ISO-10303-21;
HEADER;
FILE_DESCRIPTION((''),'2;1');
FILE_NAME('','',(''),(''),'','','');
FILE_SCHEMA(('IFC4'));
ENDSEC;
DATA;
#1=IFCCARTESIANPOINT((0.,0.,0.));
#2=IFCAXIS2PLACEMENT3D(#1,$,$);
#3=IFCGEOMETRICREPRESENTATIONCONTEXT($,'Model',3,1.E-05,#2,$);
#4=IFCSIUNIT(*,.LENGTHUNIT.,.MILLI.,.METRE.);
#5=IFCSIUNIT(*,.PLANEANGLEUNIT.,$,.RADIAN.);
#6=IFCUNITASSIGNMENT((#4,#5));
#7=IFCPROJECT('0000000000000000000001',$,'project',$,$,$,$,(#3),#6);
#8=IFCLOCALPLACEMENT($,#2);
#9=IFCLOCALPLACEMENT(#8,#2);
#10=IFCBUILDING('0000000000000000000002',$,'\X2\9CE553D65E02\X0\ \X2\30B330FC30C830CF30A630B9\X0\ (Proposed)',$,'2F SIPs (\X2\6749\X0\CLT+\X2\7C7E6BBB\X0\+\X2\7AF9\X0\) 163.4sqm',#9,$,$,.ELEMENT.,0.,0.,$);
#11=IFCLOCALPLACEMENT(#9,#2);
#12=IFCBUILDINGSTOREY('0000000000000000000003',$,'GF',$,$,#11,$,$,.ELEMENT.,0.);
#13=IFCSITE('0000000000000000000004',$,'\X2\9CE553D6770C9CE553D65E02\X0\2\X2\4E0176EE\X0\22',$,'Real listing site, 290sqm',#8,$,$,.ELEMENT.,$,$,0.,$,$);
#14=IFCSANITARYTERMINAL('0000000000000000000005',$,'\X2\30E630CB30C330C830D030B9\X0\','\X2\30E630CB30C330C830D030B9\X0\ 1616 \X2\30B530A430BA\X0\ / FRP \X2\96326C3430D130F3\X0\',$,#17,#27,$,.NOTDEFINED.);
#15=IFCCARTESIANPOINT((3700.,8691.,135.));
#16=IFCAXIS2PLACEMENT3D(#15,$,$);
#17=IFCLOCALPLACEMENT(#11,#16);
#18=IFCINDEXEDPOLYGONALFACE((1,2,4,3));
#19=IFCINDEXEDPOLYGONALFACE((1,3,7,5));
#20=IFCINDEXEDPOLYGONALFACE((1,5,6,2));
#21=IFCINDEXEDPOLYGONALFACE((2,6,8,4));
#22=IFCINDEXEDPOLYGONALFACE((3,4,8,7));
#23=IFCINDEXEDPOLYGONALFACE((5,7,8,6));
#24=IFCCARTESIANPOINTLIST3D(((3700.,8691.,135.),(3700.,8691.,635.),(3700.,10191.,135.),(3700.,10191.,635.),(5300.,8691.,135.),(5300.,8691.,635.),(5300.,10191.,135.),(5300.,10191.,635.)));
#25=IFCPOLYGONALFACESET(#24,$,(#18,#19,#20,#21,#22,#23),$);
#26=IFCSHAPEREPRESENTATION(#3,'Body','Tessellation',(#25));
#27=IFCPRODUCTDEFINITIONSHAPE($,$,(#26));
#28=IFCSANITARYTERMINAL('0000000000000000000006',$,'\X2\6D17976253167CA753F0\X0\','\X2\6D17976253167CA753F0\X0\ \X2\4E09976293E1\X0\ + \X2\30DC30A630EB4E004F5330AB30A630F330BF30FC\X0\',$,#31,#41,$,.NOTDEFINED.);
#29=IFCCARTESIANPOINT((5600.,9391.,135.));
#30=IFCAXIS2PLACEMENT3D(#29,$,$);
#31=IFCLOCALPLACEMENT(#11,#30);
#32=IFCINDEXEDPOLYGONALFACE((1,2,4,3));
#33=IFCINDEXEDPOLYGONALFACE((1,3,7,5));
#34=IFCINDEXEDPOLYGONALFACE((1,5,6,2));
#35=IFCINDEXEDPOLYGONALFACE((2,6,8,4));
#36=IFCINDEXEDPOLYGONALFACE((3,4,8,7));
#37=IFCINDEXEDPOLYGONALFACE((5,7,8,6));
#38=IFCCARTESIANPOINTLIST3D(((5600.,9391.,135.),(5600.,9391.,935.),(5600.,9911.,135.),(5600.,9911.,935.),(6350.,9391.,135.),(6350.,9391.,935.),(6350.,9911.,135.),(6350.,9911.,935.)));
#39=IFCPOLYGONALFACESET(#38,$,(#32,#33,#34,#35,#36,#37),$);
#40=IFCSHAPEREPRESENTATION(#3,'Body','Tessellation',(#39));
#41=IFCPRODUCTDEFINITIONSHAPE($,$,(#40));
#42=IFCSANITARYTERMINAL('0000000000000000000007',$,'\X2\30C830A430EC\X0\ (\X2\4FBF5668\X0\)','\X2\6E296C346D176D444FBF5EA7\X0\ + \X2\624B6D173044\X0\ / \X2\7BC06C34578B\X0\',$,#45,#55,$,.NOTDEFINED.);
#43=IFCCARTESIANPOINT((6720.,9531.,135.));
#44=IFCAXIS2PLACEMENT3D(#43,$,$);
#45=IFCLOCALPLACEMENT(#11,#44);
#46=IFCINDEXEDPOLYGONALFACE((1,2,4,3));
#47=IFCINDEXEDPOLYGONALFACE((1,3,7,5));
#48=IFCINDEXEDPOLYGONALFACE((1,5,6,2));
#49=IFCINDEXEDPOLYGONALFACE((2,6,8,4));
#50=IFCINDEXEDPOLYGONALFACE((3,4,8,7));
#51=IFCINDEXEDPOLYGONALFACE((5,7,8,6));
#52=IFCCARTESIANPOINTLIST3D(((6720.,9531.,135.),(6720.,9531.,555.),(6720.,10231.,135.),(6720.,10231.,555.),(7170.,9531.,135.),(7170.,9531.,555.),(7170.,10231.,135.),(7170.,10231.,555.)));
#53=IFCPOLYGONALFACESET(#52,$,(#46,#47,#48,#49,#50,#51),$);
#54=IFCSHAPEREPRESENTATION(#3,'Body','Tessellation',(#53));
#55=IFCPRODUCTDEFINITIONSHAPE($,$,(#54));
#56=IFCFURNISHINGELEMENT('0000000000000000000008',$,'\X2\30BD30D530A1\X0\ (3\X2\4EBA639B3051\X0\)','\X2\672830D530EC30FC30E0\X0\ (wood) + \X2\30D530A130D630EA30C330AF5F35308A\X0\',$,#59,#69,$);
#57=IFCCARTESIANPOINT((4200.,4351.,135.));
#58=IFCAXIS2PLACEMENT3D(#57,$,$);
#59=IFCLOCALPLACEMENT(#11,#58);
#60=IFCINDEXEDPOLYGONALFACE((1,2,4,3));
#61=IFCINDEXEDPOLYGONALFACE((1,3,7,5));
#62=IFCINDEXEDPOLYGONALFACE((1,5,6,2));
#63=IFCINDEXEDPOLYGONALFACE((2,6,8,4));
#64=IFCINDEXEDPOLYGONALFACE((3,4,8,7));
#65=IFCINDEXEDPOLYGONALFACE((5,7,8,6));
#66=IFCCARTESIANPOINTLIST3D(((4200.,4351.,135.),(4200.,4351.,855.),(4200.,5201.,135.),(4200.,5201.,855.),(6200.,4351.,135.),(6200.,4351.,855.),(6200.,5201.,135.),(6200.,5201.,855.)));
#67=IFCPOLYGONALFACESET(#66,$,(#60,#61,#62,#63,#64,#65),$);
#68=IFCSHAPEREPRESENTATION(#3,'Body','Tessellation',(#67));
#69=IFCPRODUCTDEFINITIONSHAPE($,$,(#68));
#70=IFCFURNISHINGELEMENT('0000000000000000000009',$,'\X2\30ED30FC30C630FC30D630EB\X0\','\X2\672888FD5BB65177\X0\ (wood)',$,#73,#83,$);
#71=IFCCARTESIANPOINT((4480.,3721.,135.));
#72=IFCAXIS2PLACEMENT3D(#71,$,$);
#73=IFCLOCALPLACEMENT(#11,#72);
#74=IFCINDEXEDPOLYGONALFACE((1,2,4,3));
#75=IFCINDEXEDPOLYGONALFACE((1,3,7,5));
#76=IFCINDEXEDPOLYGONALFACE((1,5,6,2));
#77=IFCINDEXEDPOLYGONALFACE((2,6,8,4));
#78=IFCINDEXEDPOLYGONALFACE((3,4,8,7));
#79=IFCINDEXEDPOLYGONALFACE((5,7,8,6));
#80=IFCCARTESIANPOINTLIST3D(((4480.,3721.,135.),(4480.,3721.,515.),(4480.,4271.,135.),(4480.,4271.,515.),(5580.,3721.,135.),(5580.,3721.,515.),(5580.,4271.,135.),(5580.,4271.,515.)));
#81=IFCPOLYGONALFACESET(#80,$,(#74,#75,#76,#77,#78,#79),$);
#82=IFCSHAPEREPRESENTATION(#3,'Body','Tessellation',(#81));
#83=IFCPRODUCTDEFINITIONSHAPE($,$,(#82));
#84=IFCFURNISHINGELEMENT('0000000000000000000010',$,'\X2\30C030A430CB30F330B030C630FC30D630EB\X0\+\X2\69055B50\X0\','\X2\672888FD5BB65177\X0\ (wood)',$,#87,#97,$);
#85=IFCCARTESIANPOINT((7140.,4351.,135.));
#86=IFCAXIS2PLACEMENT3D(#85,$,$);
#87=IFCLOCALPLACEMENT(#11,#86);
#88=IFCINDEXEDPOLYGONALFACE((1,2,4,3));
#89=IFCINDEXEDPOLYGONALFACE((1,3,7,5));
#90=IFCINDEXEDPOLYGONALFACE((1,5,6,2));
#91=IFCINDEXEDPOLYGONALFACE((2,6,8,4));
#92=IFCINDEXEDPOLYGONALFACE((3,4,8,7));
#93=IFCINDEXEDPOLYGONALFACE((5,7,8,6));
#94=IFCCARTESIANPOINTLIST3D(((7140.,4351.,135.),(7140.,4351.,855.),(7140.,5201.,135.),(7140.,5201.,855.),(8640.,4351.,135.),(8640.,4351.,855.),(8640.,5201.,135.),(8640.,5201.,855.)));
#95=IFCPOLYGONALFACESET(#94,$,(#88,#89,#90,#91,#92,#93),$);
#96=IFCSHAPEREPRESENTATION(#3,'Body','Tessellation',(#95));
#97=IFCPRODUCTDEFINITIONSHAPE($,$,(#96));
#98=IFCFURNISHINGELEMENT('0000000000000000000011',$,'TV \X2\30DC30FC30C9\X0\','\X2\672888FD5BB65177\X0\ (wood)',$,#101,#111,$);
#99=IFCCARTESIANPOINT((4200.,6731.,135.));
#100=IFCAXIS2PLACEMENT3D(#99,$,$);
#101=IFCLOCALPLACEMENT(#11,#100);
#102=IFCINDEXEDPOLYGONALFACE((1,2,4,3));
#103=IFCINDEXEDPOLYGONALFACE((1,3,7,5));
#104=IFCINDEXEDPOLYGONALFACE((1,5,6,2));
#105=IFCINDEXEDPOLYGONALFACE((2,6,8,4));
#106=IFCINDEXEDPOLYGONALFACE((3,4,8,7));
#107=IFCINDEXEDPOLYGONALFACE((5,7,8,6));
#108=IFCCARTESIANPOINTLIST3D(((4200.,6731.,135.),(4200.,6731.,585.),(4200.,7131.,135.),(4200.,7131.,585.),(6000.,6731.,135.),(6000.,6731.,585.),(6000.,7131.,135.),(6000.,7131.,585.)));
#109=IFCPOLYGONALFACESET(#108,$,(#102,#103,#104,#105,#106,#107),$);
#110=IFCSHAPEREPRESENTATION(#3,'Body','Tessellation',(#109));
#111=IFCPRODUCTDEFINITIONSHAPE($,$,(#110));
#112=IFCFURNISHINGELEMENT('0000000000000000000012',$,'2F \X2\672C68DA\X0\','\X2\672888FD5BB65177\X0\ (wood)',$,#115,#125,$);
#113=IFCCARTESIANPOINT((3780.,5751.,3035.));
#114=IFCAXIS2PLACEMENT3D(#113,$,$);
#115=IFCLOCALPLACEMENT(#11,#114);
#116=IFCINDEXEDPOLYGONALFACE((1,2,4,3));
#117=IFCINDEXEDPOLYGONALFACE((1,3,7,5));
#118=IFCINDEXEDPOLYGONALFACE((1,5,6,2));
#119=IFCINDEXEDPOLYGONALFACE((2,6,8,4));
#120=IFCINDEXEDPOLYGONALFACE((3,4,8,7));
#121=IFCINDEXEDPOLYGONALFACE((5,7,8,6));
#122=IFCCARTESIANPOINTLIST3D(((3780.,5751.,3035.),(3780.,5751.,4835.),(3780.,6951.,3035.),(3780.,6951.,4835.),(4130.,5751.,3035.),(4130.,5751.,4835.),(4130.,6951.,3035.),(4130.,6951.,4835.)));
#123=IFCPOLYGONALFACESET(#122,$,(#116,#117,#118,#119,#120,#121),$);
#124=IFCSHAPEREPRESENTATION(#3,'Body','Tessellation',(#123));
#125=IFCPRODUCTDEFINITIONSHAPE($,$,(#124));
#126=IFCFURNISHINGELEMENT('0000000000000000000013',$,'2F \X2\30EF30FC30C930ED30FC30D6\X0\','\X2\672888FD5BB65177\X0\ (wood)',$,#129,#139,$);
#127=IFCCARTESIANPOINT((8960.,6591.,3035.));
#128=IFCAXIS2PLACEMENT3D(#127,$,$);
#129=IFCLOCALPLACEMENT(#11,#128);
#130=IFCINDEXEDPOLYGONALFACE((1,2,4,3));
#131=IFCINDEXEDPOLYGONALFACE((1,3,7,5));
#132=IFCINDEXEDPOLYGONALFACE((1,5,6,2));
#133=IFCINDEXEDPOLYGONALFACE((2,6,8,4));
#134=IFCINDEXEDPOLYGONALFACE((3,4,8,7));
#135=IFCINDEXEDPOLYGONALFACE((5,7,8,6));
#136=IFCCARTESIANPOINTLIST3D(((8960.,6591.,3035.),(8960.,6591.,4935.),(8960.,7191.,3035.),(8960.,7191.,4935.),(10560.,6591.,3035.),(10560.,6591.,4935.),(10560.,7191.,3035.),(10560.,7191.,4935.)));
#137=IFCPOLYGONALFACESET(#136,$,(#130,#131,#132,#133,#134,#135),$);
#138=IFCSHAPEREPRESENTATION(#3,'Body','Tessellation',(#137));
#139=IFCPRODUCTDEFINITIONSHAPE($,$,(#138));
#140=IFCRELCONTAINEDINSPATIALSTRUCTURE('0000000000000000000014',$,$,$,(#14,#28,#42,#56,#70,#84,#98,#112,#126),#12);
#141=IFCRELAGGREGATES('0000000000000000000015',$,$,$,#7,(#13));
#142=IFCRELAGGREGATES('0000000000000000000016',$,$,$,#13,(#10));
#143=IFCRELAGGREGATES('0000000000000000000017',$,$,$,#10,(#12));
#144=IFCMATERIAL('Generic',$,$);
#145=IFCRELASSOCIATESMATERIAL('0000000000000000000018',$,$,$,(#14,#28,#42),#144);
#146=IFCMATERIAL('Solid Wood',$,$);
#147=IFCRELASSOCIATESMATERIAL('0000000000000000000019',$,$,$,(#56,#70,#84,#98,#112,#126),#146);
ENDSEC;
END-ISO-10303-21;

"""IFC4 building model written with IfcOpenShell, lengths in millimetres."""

from ifc_helpers import new_model, si_unit, frame, frame_2d, origin, place, context, project, spatial, rectangle, extrude, material, element, save


model = new_model("IFC4")

# Units and contexts
model_context = context("Model", 3, precision=1e-05, world=origin())
ifc_project = project(units=[si_unit("LENGTHUNIT", "METRE", prefix="MILLI"), si_unit("PLANEANGLEUNIT", "RADIAN")], contexts=[model_context])

# Site, building, storey
site_placement = place(None, origin())
site = spatial("IfcSite", under=ifc_project, at=site_placement, Name="鳥取県鳥取市2丁目22", ObjectType="Real listing site, 290sqm", CompositionType="ELEMENT", RefElevation=0.0)
building_placement = place(site_placement, origin())
building = spatial("IfcBuilding", under=site, at=building_placement, Name="鳥取市 コートハウス (Proposed)", ObjectType="2F SIPs (杉CLT+籾殻+竹) 163.4sqm", CompositionType="ELEMENT", ElevationOfRefHeight=0.0, ElevationOfTerrain=0.0)
storey_placement = place(building_placement, origin())
storey = spatial("IfcBuildingStorey", under=building, at=storey_placement, Name="GF", CompositionType="ELEMENT", Elevation=0.0)

# Shared definitions
ifc_material_1 = material(Name="Generic")

# Shared definitions
ifc_material_2 = material(Name="Solid Wood")

# Sanitary terminals
sanitary_terminal_1_placement = place(storey_placement, frame((3700.0, 8691.0, 135.0)))
element("IfcSanitaryTerminal", 1, at=sanitary_terminal_1_placement, inside=storey, material=ifc_material_1, Name="ユニットバス", Description="ユニットバス 1616 サイズ / FRP 防水パン", PredefinedType="NOTDEFINED", context=model_context, shape_type="SweptSolid", body=[
    extrude(rectangle(XDim=1600.0, YDim=1500.0, at=frame_2d((800.0, 750.0))), frame((3700.0, 8691.0, 135.0)), (0.0, 0.0, 1.0), 500.0),
])
sanitary_terminal_2_placement = place(storey_placement, frame((5600.0, 9391.0, 135.0)))
element("IfcSanitaryTerminal", 2, at=sanitary_terminal_2_placement, inside=storey, material=ifc_material_1, Name="洗面化粧台", Description="洗面化粧台 三面鏡 + ボウル一体カウンター", PredefinedType="NOTDEFINED", context=model_context, shape_type="SweptSolid", body=[
    extrude(rectangle(XDim=750.0, YDim=520.0, at=frame_2d((375.0, 260.0))), frame((5600.0, 9391.0, 135.0)), (0.0, 0.0, 1.0), 800.0),
])
sanitary_terminal_3_placement = place(storey_placement, frame((6720.0, 9531.0, 135.0)))
element("IfcSanitaryTerminal", 3, at=sanitary_terminal_3_placement, inside=storey, material=ifc_material_1, Name="トイレ (便器)", Description="温水洗浄便座 + 手洗い / 節水型", PredefinedType="NOTDEFINED", context=model_context, shape_type="SweptSolid", body=[
    extrude(rectangle(XDim=450.0, YDim=700.0, at=frame_2d((225.0, 350.0))), frame((6720.0, 9531.0, 135.0)), (0.0, 0.0, 1.0), 420.0),
])

# Furnishing elements
furnishing_1_placement = place(storey_placement, frame((4200.0, 4351.0, 135.0)))
element("IfcFurnishingElement", 4, at=furnishing_1_placement, inside=storey, material=ifc_material_2, Name="ソファ (3人掛け)", Description="木フレーム (wood) + ファブリック張り", context=model_context, shape_type="SweptSolid", body=[
    extrude(rectangle(XDim=2000.0, YDim=850.0, at=frame_2d((1000.0, 425.0))), frame((4200.0, 4351.0, 135.0)), (0.0, 0.0, 1.0), 720.0),
])
furnishing_2_placement = place(storey_placement, frame((4480.0, 3721.0, 135.0)))
element("IfcFurnishingElement", 5, at=furnishing_2_placement, inside=storey, material=ifc_material_2, Name="ローテーブル", Description="木製家具 (wood)", context=model_context, shape_type="SweptSolid", body=[
    extrude(rectangle(XDim=1100.0, YDim=550.0, at=frame_2d((550.0, 275.0))), frame((4480.0, 3721.0, 135.0)), (0.0, 0.0, 1.0), 380.0),
])
furnishing_3_placement = place(storey_placement, frame((7140.0, 4351.0, 135.0)))
element("IfcFurnishingElement", 6, at=furnishing_3_placement, inside=storey, material=ifc_material_2, Name="ダイニングテーブル+椅子", Description="木製家具 (wood)", context=model_context, shape_type="SweptSolid", body=[
    extrude(rectangle(XDim=1500.0, YDim=850.0, at=frame_2d((750.0, 425.0))), frame((7140.0, 4351.0, 135.0)), (0.0, 0.0, 1.0), 720.0),
])
furnishing_4_placement = place(storey_placement, frame((4200.0, 6731.0, 135.0)))
element("IfcFurnishingElement", 7, at=furnishing_4_placement, inside=storey, material=ifc_material_2, Name="TV ボード", Description="木製家具 (wood)", context=model_context, shape_type="SweptSolid", body=[
    extrude(rectangle(XDim=1800.0, YDim=400.0, at=frame_2d((900.0, 200.0))), frame((4200.0, 6731.0, 135.0)), (0.0, 0.0, 1.0), 450.0),
])
furnishing_5_placement = place(storey_placement, frame((3780.0, 5751.0, 3035.0)))
element("IfcFurnishingElement", 8, at=furnishing_5_placement, inside=storey, material=ifc_material_2, Name="2F 本棚", Description="木製家具 (wood)", context=model_context, shape_type="SweptSolid", body=[
    extrude(rectangle(XDim=350.0, YDim=1200.0, at=frame_2d((175.0, 600.0))), frame((3780.0, 5751.0, 3035.0)), (0.0, 0.0, 1.0), 1800.0),
])
furnishing_6_placement = place(storey_placement, frame((8960.0, 6591.0, 3035.0)))
element("IfcFurnishingElement", 9, at=furnishing_6_placement, inside=storey, material=ifc_material_2, Name="2F ワードローブ", Description="木製家具 (wood)", context=model_context, shape_type="SweptSolid", body=[
    extrude(rectangle(XDim=1600.0, YDim=600.0, at=frame_2d((800.0, 300.0))), frame((8960.0, 6591.0, 3035.0)), (0.0, 0.0, 1.0), 1900.0),
])

save(model, "model.ifc")
